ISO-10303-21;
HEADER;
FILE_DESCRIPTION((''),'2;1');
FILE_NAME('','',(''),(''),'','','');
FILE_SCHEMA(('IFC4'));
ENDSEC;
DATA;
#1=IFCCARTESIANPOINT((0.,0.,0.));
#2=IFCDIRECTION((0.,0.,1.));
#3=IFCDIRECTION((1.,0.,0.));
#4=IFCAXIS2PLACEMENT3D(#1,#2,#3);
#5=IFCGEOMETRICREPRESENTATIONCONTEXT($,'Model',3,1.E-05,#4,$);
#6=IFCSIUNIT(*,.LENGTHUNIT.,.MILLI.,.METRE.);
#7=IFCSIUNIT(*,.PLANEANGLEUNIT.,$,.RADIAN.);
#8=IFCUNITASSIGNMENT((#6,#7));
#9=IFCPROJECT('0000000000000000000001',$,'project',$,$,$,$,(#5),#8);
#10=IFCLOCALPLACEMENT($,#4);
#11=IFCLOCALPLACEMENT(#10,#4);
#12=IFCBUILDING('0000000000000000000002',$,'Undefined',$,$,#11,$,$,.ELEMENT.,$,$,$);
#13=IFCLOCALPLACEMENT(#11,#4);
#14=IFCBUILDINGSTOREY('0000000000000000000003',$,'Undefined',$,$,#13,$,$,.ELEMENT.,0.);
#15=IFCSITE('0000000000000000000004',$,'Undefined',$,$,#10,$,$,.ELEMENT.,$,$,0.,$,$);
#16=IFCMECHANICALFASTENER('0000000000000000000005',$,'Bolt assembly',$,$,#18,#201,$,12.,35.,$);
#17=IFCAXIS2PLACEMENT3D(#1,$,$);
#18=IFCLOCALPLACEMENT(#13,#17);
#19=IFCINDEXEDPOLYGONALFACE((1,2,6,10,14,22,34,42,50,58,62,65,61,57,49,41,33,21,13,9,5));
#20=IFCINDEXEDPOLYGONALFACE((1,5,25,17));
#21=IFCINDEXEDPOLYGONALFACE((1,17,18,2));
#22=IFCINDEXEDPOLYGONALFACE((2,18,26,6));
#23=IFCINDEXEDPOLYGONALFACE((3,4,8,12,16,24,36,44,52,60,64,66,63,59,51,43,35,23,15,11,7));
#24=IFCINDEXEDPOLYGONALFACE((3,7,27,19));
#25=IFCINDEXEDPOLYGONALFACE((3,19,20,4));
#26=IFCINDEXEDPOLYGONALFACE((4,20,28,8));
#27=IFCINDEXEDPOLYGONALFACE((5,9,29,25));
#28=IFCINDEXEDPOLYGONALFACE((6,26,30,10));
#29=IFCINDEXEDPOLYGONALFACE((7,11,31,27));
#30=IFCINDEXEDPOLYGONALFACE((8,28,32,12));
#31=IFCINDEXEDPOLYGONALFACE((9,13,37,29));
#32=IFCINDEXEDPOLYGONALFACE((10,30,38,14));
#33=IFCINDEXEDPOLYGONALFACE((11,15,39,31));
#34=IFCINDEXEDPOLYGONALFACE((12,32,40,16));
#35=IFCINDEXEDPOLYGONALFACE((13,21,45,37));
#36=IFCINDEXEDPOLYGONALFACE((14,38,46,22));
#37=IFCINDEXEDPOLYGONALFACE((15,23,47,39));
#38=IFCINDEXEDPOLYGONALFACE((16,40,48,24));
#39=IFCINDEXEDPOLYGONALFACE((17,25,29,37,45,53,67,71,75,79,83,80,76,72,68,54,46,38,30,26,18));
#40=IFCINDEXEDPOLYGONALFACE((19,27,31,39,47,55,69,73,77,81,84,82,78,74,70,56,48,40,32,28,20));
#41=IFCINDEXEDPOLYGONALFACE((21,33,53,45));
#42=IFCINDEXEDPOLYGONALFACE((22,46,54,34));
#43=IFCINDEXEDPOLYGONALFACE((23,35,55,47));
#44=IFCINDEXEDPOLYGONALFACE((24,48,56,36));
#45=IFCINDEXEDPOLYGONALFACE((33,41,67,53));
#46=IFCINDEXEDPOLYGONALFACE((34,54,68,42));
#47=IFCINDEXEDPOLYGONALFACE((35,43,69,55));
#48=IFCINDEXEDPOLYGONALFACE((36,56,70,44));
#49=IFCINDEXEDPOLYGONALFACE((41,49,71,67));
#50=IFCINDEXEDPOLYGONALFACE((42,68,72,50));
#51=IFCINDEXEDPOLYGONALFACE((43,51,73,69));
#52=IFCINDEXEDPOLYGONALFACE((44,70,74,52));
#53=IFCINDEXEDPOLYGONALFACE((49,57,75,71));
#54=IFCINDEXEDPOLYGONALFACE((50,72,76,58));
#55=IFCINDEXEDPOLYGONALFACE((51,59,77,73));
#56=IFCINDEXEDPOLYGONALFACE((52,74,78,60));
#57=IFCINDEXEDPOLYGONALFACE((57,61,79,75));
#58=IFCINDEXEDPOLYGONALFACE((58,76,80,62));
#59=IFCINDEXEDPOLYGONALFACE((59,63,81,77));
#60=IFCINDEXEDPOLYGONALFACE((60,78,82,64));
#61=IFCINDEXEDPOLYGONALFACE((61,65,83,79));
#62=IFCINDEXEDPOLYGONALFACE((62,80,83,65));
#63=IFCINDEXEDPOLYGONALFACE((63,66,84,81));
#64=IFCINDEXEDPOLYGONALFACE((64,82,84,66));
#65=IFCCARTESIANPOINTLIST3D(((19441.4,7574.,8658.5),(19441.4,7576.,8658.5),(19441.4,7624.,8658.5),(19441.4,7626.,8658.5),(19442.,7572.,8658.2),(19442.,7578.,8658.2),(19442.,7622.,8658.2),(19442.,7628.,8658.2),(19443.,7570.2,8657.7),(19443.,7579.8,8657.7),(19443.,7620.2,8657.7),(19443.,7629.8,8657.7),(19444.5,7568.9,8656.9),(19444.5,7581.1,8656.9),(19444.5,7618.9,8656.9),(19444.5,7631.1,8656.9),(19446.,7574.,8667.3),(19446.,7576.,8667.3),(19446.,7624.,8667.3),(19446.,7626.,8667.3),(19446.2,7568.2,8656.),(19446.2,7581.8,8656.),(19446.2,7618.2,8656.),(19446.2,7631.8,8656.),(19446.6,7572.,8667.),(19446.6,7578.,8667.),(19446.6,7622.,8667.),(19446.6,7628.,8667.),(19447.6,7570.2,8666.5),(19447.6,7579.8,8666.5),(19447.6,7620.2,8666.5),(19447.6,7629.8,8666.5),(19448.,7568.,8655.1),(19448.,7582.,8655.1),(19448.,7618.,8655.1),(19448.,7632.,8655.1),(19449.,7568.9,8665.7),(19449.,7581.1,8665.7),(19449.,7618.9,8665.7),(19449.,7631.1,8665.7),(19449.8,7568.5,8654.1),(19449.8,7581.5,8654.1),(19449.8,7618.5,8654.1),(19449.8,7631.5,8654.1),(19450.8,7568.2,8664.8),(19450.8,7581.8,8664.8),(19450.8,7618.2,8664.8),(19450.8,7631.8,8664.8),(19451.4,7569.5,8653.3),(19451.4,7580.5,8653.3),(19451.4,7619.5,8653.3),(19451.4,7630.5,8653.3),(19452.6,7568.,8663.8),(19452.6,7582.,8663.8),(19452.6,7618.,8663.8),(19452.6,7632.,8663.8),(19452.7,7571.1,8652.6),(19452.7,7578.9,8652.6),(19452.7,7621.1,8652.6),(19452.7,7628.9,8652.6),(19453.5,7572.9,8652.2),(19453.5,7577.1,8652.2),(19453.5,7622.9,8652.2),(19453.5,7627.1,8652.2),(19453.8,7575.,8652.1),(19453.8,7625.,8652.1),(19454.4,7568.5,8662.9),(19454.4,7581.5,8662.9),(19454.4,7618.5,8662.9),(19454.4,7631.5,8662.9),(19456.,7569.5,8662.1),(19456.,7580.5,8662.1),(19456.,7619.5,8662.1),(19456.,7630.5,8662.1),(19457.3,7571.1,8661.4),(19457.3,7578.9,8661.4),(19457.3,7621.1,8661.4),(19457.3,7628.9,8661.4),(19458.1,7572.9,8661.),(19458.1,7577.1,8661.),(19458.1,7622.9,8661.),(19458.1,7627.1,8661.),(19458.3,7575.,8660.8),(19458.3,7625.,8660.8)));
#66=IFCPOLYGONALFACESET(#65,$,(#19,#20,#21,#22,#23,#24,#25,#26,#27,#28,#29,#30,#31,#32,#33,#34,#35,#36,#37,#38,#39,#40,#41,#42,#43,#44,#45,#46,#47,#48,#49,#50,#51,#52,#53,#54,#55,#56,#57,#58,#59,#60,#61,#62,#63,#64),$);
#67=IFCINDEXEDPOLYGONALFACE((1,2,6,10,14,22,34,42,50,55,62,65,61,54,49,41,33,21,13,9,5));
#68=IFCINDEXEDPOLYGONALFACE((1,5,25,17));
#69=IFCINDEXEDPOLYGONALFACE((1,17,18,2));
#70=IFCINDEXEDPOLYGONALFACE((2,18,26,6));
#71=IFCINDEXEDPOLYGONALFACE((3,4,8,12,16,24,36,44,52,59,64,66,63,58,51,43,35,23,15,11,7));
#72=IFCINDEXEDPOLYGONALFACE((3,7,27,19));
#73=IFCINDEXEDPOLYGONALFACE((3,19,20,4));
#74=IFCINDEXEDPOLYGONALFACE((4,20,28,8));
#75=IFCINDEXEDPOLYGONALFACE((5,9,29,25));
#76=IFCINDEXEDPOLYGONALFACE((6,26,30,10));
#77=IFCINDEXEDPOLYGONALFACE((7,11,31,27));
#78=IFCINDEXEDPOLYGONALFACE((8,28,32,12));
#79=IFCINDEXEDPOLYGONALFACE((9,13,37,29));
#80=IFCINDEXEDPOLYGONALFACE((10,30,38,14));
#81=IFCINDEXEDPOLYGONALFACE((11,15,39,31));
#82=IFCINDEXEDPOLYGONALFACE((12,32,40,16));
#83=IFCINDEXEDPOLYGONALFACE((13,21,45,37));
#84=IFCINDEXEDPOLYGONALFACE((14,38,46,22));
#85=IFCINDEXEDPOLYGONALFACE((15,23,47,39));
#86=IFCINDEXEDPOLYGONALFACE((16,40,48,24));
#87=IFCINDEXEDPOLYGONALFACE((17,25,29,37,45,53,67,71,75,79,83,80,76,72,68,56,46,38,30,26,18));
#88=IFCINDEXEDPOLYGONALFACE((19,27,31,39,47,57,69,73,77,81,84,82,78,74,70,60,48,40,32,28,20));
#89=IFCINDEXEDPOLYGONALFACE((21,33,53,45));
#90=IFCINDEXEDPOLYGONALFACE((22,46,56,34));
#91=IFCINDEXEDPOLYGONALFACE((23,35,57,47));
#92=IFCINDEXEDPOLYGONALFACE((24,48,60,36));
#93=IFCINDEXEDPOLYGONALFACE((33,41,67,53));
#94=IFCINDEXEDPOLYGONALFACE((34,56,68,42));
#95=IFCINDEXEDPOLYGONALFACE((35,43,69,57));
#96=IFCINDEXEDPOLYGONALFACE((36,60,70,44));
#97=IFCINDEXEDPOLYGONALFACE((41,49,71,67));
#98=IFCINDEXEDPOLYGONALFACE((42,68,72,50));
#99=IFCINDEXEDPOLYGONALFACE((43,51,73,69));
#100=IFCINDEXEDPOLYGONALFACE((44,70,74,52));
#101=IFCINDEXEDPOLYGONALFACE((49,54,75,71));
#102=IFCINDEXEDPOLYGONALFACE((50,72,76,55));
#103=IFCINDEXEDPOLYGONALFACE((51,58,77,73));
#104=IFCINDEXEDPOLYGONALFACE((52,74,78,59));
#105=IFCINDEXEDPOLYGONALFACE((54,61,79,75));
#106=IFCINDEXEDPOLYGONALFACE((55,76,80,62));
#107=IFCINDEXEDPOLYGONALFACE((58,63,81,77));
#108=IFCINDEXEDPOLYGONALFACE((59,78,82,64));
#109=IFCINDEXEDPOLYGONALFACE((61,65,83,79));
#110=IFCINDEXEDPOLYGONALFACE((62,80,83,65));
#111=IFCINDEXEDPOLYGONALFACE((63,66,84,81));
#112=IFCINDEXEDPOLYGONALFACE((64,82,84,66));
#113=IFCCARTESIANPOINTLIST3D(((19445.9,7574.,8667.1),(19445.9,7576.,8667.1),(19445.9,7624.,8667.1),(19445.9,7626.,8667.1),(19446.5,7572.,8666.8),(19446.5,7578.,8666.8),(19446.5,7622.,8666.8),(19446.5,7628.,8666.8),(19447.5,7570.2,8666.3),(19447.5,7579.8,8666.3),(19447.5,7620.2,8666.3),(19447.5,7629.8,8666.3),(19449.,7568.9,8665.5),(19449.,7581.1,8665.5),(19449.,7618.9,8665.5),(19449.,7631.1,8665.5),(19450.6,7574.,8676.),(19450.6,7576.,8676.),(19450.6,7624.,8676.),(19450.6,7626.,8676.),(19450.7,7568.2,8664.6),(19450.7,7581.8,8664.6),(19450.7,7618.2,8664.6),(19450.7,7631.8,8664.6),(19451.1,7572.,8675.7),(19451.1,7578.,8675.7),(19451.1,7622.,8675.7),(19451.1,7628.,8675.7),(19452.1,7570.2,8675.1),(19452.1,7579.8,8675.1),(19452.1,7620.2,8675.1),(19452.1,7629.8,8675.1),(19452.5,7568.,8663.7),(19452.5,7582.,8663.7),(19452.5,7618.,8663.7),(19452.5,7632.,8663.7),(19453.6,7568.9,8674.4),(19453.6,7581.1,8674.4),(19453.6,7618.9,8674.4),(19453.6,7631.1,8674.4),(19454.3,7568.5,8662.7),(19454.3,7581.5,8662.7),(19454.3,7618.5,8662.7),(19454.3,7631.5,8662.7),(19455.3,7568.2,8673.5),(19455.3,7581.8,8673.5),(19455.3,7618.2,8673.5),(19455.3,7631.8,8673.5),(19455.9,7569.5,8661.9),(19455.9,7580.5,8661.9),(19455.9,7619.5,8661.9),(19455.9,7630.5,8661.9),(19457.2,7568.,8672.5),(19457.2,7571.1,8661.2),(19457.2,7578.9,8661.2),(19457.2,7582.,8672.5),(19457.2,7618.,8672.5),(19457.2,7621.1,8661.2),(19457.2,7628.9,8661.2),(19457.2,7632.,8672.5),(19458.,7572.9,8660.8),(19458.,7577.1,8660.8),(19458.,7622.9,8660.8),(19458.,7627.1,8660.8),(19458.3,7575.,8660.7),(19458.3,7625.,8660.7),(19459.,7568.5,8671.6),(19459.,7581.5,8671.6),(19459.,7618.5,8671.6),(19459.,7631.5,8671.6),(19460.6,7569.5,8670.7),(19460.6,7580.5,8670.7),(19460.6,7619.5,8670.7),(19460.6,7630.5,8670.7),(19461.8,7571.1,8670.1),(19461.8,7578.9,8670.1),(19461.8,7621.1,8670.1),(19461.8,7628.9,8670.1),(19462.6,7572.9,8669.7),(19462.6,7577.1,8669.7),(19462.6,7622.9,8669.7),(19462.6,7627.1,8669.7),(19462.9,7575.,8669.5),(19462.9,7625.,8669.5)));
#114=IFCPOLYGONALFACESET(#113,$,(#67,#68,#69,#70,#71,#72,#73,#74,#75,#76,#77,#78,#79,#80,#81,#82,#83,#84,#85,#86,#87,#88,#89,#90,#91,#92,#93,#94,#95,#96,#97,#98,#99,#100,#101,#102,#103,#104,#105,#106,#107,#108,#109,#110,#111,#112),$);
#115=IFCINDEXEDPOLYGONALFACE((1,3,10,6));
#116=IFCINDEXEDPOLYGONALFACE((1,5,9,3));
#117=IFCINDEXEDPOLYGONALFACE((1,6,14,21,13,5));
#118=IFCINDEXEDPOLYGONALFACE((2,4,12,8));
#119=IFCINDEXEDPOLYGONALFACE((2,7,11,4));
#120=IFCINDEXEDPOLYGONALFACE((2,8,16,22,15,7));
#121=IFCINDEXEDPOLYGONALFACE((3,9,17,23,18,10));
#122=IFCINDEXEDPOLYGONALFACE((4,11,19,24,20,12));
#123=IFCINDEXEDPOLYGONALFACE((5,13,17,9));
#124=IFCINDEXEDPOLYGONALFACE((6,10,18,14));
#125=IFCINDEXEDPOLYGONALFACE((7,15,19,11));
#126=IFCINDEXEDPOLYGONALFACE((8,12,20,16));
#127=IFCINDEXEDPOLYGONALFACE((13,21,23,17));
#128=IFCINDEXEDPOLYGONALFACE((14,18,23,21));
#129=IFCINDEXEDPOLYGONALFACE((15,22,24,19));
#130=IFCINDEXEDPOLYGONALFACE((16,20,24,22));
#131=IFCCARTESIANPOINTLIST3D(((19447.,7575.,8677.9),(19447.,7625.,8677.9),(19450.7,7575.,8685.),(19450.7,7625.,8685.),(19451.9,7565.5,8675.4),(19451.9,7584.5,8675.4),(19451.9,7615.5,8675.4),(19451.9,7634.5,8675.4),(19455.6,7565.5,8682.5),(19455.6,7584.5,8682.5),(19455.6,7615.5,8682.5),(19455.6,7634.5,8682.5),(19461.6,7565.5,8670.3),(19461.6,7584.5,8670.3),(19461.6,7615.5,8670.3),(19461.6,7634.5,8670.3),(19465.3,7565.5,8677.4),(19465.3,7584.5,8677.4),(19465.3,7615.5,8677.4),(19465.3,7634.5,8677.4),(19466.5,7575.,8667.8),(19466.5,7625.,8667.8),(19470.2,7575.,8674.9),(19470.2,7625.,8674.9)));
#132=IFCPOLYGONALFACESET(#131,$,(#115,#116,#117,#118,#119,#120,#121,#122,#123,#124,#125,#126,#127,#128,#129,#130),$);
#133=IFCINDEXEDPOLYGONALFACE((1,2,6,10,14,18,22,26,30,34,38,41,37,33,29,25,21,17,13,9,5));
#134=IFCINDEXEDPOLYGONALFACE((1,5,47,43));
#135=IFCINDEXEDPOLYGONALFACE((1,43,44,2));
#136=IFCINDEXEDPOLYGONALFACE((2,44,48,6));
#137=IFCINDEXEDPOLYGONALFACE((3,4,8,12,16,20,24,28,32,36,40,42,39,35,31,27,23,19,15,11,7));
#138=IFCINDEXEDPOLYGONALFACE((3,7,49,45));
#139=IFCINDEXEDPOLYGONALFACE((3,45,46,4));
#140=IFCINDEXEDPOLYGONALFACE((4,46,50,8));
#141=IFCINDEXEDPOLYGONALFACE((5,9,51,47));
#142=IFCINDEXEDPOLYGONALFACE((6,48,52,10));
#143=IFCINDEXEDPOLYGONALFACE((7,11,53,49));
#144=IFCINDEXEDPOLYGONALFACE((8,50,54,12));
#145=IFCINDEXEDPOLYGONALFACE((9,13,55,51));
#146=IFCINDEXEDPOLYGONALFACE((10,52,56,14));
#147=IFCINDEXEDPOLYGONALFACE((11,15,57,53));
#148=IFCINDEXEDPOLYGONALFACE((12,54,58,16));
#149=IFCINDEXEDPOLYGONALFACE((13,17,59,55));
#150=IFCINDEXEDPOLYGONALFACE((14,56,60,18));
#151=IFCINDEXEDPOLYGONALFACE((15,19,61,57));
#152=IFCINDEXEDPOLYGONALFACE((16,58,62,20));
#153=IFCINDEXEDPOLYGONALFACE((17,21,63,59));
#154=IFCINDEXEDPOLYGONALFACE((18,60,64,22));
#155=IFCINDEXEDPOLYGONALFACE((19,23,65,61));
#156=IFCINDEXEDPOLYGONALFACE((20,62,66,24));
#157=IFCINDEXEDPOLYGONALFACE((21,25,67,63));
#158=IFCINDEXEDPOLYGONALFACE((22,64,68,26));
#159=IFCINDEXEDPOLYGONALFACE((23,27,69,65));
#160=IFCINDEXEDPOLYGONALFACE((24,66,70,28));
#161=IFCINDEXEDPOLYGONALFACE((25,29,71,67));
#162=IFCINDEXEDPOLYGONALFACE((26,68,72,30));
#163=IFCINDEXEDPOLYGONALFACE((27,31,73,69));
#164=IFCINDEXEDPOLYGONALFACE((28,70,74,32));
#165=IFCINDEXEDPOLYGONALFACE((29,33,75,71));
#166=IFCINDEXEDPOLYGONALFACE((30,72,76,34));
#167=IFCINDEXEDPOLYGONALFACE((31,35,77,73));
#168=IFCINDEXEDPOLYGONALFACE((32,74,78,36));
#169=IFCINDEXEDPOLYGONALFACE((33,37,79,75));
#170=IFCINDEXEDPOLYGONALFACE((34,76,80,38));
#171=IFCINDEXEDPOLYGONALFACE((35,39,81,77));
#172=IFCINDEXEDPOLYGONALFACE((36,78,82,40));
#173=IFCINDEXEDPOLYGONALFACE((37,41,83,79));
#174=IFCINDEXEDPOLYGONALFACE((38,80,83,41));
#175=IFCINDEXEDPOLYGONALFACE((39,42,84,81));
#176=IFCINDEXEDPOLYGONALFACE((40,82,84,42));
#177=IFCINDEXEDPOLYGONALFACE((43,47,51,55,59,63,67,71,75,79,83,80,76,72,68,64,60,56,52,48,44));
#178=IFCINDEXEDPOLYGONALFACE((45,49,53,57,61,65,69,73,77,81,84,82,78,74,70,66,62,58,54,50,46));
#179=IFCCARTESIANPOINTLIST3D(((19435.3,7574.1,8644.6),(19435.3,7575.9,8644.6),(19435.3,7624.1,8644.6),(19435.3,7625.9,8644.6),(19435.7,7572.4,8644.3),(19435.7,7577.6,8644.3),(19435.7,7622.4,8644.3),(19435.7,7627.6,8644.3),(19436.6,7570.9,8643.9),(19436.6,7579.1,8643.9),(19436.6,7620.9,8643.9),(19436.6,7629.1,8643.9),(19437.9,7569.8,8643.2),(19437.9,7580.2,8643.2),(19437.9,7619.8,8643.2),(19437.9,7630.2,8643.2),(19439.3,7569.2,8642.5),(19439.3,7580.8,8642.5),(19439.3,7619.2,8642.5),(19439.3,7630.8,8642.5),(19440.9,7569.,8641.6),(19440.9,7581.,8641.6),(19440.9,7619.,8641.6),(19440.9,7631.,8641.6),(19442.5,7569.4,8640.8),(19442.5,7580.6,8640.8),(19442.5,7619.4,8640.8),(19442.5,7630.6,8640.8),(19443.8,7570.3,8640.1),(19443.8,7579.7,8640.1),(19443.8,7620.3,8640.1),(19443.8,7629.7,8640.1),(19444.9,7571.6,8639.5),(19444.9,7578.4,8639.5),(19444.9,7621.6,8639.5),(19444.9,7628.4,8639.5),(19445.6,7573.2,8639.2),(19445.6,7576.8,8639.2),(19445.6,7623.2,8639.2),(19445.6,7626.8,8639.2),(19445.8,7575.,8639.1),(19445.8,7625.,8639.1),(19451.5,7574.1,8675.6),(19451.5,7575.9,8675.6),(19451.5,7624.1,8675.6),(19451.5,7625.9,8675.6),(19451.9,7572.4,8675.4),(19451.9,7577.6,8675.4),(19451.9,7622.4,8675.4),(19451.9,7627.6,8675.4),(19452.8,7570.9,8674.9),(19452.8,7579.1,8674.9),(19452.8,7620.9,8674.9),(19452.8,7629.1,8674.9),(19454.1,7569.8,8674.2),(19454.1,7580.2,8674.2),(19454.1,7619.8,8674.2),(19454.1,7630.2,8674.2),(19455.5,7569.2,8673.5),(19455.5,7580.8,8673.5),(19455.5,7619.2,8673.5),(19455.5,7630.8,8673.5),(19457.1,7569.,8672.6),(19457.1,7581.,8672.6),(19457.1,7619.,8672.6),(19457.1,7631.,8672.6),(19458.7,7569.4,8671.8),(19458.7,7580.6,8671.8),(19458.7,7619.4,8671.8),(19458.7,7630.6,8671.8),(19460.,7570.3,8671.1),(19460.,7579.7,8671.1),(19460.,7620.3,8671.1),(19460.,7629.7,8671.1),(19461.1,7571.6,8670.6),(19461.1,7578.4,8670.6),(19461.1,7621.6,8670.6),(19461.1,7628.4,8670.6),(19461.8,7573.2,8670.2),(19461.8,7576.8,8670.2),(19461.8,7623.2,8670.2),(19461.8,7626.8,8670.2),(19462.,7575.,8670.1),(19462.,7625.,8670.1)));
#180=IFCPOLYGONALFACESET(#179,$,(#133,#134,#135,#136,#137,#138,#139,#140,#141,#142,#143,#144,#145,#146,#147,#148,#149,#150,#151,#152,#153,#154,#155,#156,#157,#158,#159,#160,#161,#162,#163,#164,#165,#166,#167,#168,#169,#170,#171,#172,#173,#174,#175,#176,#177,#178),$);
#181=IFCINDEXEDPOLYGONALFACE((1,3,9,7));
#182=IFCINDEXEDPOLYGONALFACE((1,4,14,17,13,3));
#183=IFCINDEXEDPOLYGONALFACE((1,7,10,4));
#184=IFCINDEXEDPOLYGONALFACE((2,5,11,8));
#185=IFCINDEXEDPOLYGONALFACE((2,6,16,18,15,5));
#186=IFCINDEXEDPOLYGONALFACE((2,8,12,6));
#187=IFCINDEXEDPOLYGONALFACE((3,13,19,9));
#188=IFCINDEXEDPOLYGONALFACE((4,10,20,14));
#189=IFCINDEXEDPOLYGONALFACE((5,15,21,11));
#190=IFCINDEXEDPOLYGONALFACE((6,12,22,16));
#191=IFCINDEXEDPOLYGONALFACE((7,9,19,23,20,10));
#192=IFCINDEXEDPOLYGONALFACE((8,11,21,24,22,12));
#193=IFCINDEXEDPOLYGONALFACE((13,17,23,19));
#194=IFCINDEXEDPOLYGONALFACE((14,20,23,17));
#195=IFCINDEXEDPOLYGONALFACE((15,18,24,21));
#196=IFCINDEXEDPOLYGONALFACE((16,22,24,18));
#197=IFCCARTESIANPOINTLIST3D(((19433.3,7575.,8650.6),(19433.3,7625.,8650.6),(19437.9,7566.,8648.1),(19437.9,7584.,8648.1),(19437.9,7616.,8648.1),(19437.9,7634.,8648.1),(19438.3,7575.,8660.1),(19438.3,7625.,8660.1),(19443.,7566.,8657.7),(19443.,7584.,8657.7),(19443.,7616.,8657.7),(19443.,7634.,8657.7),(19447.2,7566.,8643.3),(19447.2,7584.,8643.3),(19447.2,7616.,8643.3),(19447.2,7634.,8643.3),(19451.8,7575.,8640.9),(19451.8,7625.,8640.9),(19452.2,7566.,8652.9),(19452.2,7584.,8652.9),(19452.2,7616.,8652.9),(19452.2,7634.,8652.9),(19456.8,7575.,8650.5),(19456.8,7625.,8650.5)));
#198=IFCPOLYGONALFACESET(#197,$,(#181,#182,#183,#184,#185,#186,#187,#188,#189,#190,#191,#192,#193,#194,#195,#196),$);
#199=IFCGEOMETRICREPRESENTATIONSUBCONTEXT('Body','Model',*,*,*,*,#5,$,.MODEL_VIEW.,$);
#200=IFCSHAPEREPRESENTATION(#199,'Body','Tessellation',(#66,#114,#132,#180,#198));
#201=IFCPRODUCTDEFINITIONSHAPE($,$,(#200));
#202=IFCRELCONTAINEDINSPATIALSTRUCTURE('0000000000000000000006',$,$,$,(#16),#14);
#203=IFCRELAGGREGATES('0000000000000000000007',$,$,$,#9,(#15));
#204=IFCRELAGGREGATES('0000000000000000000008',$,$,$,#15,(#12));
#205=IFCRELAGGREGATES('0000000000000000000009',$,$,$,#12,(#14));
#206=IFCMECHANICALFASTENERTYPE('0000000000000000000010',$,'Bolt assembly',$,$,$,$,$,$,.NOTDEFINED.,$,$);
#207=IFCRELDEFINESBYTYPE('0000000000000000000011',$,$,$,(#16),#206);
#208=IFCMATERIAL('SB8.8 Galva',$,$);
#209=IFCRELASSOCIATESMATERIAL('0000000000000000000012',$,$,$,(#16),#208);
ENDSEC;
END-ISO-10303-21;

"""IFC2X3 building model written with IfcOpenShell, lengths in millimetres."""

from ifc_helpers import new_model, si_unit, frame, origin_with_axes, origin_2d_with_axis, place, context, subcontext, project, spatial, polyline, circle, outline, extrude, source, transform, mapped, material, type_object, element, save


model = new_model("IFC2X3")

# Units and contexts
model_context = context("Model", 3, precision=1e-05, world=origin_with_axes())
body_context = subcontext(model_context, "Body", "Model", "MODEL_VIEW")
ifc_project = project(units=[si_unit("LENGTHUNIT", "METRE", prefix="MILLI"), si_unit("PLANEANGLEUNIT", "RADIAN")], contexts=[model_context])

# Site, building, storey
site_placement = place(None, origin_with_axes())
site = spatial("IfcSite", under=ifc_project, at=site_placement, Name="Undefined", CompositionType="ELEMENT", RefElevation=0.0)
building_placement = place(site_placement, origin_with_axes())
building = spatial("IfcBuilding", under=site, at=building_placement, Name="Undefined", CompositionType="ELEMENT")
storey_placement = place(building_placement, origin_with_axes())
storey = spatial("IfcBuildingStorey", under=building, at=storey_placement, Name="Undefined", CompositionType="ELEMENT", Elevation=0.0)

# Mechanical fastener
mechanical_fastener_type = type_object("IfcMechanicalFastenerType", Name="Bolt assembly")
ifc_material_1 = material(Name="SB8.8 Galva")
shared_shape_1 = source(origin_with_axes(), body_context, "Body", "SweptSolid", [
    extrude(circle(Radius=7.0, at=origin_2d_with_axis()), frame((0.0, -0.1, 0.0), z_axis=(0.0, 1.0, 0.0), x_axis=(1.0, 0.0, 0.0)), (0.0, 0.0, 1.0), 9.9),
    extrude(circle(Radius=7.0, at=origin_2d_with_axis()), frame((0.0, -9.9, 0.0), z_axis=(0.0, 1.0, 0.0), x_axis=(1.0, 0.0, 0.0)), (0.0, 0.0, 1.0), 10.0),
    extrude(outline(polyline([(11.0, 0.0), (5.5, 9.5), (-5.5, 9.5), (-11.0, 0.0), (-5.5, -9.5), (5.5, -9.5), (11.0, 0.0)])), frame((0.0, -18.0, 0.0), z_axis=(0.0, 1.0, 0.0), x_axis=(1.0, 0.0, 0.0)), (0.0, 0.0, 1.0), 8.0),
    extrude(circle(Radius=6.0, at=origin_2d_with_axis()), frame((0.0, -10.0, 0.0), z_axis=(0.0, 1.0, 0.0), x_axis=(1.0, 0.0, 0.0)), (0.0, 0.0, 1.0), 35.0),
    extrude(outline(polyline([(10.4, 0.0), (5.2, 9.0), (-5.2, 9.0), (-10.4, 0.0), (-5.2, -9.0), (5.2, -9.0), (10.4, 0.0)])), frame((0.0, 9.8, 0.0), z_axis=(0.0, 1.0, 0.0), x_axis=(1.0, 0.0, 0.0)), (0.0, 0.0, 1.0), 10.8),
])
for number, where, z_axis, x_axis, name in (
    (1, (19452.1, 7600.0, 8664.0), (0.0, 1.0, 0.0), (0.886082, 0.0, -0.463529), "Bolt assembly"),
):
    element("IfcMechanicalFastener", number, at=place(storey_placement, frame(where, z_axis=z_axis, x_axis=x_axis)), inside=storey, type_object=mechanical_fastener_type, material=ifc_material_1, Name=name, NominalDiameter=12.0, NominalLength=35.0, context=body_context, shape_type="MappedRepresentation", body=[
        mapped(shared_shape_1, transform((0.0, 0.0, -25.0))),
        mapped(shared_shape_1, transform((0.0, 0.0, 25.0))),
    ])

save(model, "model.ifc")
